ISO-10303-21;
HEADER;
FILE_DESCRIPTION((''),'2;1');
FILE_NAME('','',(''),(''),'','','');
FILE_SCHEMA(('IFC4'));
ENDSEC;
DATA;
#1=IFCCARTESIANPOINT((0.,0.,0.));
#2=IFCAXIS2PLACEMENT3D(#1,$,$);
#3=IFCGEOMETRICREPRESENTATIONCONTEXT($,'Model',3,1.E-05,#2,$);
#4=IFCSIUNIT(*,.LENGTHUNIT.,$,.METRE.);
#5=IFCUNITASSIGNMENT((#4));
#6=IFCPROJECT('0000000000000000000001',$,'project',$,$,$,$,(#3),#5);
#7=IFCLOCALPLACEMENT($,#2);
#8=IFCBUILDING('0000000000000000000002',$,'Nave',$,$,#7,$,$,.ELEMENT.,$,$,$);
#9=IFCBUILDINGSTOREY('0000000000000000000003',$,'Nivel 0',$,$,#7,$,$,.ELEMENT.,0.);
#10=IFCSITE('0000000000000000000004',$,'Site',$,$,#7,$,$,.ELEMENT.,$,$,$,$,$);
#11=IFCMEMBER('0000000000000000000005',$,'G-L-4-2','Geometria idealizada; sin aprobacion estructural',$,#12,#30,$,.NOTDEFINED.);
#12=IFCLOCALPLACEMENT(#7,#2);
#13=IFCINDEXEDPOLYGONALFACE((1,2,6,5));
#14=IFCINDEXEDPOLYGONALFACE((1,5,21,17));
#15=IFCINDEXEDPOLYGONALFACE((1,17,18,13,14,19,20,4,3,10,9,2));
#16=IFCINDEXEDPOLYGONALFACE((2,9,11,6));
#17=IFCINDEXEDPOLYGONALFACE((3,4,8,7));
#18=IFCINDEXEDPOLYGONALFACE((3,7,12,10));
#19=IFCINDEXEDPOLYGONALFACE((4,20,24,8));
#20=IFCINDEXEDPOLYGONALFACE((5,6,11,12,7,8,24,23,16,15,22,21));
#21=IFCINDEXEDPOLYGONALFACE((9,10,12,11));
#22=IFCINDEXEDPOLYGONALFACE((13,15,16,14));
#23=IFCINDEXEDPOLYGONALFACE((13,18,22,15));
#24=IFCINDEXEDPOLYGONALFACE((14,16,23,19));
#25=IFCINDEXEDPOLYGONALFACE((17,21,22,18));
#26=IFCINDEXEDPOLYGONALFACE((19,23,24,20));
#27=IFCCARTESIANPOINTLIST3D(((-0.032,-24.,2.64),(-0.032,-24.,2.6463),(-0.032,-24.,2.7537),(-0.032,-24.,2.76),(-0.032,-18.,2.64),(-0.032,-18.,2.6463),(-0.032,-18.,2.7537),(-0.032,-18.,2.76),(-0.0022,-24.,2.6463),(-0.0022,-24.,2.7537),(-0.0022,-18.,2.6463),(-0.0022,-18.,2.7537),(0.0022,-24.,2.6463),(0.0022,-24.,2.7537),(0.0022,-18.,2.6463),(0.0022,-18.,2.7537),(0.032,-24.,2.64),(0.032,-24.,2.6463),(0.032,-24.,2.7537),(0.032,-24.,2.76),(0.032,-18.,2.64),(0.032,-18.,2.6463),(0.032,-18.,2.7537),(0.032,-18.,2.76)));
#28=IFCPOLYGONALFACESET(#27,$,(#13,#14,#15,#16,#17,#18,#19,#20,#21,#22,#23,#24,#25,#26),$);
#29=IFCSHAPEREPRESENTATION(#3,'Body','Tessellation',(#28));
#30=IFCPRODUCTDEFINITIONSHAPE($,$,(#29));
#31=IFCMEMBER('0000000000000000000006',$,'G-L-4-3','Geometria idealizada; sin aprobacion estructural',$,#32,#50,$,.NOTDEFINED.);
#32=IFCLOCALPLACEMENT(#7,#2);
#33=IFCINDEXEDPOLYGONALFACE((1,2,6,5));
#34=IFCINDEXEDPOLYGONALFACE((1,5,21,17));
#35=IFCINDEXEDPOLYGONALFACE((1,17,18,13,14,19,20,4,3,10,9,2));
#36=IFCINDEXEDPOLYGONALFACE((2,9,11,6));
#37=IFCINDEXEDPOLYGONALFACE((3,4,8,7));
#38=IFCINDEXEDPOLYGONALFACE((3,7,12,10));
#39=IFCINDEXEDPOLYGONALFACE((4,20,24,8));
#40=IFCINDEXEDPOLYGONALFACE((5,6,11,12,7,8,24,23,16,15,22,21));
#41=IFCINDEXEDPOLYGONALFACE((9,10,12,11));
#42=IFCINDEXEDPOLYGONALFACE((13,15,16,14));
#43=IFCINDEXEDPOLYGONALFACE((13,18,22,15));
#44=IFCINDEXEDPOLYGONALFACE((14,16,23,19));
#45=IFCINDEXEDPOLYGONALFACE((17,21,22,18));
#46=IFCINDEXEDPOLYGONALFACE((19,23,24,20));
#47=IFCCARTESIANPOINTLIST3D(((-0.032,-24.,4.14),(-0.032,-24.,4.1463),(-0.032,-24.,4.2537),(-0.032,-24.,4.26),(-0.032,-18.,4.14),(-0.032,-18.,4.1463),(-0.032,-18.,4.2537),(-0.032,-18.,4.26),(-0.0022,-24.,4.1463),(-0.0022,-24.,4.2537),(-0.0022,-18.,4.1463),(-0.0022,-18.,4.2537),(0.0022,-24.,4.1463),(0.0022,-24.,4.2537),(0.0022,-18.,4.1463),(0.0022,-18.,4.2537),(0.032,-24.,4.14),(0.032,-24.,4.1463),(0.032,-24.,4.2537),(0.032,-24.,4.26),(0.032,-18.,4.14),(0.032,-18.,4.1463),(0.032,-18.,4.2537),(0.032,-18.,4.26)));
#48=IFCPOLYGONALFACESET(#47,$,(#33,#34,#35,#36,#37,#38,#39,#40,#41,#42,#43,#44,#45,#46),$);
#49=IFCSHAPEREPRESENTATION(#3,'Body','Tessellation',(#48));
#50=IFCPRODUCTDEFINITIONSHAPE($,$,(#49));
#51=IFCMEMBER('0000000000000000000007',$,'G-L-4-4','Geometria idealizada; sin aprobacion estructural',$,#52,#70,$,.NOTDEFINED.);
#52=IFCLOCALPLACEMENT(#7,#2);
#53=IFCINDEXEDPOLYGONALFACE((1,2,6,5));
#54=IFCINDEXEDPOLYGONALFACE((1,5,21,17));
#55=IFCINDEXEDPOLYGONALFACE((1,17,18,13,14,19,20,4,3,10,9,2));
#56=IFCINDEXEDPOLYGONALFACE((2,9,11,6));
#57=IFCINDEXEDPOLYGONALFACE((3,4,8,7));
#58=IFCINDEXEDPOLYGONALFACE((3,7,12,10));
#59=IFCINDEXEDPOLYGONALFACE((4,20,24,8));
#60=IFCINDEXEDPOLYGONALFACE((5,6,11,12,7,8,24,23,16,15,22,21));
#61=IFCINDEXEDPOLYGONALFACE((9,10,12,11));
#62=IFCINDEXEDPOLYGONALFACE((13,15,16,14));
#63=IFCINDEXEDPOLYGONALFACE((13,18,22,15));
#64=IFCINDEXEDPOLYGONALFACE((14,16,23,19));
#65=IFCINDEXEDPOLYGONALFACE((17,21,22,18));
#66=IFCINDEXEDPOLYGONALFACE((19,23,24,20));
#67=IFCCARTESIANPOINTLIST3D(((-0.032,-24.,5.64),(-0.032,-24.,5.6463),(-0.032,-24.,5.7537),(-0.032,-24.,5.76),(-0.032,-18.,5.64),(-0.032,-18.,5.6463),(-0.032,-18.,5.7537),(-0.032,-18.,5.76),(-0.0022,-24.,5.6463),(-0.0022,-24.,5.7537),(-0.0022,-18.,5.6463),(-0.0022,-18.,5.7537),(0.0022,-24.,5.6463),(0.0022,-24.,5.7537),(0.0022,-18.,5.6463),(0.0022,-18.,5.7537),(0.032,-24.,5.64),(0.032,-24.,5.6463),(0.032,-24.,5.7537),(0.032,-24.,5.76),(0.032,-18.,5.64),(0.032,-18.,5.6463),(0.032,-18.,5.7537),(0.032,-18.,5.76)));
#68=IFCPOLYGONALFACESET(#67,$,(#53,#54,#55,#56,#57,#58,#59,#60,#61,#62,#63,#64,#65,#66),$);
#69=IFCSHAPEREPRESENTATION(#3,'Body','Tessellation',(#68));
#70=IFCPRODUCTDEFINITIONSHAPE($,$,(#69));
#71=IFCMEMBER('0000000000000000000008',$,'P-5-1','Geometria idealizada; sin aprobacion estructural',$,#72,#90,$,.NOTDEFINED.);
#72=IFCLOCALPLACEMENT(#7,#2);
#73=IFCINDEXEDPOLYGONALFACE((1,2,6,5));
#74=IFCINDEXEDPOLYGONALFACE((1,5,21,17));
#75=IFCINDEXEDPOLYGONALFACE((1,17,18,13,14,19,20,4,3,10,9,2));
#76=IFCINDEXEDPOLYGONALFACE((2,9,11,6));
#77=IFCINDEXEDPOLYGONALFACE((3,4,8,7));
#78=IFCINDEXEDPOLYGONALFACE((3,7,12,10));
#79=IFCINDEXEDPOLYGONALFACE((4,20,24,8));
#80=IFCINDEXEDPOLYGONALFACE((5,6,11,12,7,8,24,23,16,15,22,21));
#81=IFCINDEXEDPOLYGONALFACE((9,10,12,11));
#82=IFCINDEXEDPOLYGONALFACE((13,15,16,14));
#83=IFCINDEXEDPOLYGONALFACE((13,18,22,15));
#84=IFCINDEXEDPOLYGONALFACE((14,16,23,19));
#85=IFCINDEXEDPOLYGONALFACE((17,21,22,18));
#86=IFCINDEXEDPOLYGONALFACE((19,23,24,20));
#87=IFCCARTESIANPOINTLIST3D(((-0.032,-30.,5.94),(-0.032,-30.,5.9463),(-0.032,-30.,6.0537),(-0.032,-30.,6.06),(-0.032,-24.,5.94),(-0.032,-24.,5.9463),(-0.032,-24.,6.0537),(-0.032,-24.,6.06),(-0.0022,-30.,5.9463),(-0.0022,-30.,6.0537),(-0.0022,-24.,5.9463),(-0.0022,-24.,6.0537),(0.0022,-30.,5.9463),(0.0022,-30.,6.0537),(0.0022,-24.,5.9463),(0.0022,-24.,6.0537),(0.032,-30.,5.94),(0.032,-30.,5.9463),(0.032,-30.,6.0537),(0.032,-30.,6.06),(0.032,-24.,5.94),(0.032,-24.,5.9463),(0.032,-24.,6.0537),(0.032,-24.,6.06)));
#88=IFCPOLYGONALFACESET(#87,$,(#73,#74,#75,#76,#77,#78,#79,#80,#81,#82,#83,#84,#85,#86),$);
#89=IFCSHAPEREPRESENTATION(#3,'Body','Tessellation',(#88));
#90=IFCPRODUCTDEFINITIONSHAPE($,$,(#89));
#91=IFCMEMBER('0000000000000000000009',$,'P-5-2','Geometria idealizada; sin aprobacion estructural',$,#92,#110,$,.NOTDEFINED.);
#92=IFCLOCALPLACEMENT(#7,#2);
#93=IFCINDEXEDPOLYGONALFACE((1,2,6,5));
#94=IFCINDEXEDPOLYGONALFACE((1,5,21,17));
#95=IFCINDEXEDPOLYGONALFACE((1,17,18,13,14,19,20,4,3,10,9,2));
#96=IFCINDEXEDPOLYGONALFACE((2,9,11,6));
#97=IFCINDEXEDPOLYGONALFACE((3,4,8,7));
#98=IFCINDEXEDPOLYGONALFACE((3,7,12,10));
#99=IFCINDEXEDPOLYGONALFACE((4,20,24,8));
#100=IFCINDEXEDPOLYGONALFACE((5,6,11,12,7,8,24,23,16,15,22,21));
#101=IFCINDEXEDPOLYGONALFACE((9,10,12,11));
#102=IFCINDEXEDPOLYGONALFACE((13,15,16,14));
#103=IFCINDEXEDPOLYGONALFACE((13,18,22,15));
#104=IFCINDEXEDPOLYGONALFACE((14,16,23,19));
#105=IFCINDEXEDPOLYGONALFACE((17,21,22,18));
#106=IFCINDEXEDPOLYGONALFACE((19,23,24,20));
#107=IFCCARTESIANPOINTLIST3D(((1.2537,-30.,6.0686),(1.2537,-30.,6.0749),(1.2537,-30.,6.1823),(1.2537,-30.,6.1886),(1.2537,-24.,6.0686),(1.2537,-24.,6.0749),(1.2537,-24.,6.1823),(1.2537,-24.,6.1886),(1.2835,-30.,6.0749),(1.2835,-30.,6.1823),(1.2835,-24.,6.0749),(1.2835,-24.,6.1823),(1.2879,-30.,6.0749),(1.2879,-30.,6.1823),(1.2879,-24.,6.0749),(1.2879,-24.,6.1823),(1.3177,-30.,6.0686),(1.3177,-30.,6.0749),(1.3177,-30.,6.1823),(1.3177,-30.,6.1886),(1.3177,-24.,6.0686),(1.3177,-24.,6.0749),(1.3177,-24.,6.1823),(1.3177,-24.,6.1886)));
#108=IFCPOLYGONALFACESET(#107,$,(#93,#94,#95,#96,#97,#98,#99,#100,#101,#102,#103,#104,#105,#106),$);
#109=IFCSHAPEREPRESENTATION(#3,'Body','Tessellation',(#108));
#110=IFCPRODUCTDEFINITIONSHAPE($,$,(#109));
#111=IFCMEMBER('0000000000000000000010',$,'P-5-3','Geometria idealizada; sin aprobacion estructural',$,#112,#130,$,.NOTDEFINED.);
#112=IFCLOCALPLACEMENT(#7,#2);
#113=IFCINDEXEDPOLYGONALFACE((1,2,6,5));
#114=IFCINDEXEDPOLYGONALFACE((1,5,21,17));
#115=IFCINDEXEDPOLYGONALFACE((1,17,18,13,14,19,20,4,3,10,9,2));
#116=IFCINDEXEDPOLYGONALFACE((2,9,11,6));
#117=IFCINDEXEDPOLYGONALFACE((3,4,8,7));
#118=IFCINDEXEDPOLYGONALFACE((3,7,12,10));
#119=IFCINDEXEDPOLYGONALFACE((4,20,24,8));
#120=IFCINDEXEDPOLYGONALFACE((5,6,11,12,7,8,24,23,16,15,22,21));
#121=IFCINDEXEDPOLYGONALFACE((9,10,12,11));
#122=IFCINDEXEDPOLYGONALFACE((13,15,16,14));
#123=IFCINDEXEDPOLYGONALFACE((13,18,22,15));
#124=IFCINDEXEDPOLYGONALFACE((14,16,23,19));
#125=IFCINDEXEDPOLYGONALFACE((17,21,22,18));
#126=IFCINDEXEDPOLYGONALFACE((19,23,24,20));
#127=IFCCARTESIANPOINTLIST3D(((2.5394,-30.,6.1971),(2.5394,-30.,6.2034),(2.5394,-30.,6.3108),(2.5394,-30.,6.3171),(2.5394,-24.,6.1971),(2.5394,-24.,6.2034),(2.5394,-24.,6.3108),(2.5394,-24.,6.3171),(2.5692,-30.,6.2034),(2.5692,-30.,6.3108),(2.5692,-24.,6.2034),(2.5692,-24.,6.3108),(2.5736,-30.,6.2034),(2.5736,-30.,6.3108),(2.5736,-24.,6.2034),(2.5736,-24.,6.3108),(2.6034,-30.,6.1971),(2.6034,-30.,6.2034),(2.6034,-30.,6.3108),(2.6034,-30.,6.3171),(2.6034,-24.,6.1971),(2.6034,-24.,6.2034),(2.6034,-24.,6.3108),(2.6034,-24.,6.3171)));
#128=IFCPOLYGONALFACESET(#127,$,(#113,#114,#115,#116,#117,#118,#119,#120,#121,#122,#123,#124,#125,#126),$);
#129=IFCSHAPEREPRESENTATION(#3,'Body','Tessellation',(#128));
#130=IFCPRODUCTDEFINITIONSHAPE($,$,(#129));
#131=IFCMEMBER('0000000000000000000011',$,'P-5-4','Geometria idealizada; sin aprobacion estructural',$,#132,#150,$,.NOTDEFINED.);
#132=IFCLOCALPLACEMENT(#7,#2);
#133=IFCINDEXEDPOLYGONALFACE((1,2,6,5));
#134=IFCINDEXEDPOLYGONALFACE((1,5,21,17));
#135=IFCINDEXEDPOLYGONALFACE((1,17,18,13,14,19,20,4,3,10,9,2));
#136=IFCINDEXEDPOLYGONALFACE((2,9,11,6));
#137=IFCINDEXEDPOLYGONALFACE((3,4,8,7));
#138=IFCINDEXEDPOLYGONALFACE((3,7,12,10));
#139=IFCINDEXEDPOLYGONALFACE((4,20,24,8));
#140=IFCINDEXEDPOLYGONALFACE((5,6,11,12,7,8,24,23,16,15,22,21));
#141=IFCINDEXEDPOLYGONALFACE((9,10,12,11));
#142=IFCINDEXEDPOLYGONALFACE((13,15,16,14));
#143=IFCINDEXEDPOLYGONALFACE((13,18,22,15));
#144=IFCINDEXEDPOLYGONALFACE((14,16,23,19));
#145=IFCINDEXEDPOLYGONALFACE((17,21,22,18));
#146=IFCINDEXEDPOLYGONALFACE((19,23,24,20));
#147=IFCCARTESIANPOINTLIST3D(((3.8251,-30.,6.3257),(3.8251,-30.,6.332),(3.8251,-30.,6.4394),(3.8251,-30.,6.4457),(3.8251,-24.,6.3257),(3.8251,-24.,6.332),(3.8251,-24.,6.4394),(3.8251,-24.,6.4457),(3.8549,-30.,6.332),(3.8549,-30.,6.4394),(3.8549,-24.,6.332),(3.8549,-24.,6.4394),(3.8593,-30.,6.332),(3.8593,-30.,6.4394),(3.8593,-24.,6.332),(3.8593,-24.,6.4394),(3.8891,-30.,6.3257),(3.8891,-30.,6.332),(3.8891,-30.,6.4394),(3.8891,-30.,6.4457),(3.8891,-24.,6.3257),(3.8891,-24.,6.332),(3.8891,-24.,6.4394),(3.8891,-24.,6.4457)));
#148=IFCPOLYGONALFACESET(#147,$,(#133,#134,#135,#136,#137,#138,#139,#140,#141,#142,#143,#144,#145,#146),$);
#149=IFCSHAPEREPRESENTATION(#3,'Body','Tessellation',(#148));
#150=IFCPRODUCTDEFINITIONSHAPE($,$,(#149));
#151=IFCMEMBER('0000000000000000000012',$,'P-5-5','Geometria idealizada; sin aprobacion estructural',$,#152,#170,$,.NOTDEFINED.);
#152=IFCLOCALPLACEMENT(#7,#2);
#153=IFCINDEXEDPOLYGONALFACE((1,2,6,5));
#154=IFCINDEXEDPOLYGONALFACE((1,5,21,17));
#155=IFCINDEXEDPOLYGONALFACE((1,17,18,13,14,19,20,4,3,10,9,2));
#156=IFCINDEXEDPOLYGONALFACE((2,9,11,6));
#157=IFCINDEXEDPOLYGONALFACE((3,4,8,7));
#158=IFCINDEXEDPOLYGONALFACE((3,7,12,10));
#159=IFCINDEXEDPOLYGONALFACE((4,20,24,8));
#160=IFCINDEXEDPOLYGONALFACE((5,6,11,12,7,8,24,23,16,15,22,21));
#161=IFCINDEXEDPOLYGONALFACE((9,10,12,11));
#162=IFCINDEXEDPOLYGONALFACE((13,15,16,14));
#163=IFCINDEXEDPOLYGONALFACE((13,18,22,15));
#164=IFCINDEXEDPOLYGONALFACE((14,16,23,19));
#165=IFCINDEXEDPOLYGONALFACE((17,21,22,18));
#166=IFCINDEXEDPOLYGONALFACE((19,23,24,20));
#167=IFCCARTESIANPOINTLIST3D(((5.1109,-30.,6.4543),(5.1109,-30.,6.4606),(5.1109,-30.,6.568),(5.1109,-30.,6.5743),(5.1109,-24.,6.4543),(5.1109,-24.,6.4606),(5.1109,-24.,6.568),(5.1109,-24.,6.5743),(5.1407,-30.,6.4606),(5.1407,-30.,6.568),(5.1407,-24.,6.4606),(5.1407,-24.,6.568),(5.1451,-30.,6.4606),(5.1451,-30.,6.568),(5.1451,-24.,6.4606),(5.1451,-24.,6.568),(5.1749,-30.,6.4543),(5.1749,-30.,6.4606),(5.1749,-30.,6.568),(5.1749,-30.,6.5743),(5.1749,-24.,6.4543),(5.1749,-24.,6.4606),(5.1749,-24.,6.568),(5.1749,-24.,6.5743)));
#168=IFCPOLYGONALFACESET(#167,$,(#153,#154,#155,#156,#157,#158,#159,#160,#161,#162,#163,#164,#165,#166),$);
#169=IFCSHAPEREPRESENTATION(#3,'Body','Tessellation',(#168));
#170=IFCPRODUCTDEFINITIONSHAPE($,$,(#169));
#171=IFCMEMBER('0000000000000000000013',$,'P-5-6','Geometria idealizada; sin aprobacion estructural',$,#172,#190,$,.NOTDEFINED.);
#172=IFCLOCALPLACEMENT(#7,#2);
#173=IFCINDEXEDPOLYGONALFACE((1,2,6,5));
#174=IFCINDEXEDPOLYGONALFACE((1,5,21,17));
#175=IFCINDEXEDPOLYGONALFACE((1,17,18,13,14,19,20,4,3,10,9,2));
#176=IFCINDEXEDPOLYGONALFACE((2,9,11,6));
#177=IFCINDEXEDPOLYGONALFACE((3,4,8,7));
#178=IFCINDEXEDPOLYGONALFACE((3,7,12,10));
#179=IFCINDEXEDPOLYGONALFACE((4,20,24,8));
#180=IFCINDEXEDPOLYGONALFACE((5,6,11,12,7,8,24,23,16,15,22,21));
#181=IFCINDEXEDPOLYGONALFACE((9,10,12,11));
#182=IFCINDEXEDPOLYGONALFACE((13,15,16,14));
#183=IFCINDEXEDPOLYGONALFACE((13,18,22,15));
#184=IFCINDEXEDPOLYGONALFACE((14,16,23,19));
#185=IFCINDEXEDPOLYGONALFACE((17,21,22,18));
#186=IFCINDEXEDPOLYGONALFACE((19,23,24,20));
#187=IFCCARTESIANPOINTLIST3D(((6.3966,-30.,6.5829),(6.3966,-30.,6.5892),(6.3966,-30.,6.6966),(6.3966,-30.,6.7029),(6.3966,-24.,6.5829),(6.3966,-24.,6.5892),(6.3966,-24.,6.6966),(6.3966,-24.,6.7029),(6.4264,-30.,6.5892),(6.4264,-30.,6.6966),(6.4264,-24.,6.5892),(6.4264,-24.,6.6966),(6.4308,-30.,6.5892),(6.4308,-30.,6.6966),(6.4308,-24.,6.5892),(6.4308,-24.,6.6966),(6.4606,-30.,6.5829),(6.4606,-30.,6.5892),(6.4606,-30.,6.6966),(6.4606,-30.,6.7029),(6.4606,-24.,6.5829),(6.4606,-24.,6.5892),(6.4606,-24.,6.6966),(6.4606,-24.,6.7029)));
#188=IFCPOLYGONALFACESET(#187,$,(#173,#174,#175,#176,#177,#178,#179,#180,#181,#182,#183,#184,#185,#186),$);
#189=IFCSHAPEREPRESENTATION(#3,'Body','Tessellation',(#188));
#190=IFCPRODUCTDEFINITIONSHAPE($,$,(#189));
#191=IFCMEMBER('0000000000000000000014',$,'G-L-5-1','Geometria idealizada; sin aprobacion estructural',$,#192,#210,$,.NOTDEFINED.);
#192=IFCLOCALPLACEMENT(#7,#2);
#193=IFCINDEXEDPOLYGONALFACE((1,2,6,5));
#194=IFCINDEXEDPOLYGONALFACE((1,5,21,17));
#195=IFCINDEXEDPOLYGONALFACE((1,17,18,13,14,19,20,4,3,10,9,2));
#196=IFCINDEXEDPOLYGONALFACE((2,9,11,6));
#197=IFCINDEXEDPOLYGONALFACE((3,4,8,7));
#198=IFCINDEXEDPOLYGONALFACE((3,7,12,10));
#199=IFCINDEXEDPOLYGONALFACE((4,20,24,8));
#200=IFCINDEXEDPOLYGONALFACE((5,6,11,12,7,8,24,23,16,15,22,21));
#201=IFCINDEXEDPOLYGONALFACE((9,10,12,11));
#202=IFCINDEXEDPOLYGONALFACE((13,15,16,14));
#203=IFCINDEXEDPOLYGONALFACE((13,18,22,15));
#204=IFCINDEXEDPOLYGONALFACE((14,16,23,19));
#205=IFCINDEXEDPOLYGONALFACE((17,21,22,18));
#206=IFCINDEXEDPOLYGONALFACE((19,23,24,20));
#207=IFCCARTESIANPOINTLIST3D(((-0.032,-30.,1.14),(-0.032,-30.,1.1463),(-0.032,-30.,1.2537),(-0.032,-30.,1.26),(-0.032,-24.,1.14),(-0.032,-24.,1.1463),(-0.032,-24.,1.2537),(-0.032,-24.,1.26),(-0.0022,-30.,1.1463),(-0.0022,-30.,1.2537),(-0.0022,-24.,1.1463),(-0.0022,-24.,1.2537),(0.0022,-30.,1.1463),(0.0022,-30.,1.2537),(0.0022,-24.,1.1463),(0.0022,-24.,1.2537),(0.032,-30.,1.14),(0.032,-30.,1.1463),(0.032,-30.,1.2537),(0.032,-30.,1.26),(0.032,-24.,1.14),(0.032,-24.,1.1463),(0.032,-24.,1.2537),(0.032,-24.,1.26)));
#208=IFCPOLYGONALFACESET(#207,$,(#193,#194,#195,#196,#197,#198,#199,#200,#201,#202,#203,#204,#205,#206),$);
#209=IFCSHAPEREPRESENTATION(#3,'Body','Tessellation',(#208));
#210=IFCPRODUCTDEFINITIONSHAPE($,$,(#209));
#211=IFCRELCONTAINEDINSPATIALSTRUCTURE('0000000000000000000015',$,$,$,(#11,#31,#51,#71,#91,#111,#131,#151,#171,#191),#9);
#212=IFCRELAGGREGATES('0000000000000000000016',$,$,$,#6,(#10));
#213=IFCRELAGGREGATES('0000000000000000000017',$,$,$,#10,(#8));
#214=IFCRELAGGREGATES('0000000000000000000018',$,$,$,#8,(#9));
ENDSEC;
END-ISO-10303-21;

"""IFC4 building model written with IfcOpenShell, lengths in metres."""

from ifc_helpers import new_model, si_unit, frame, origin, place, context, project, spatial, polyline, outline, extrude, element, save


model = new_model("IFC4")

# Units and contexts
model_context = context("Model", 3, precision=1e-05, world=origin())
ifc_project = project(units=[si_unit("LENGTHUNIT", "METRE")], contexts=[model_context])

# Site, building, storey
placement = place(None, origin())
site = spatial("IfcSite", under=ifc_project, at=placement, Name="Site", CompositionType="ELEMENT")
building = spatial("IfcBuilding", under=site, at=placement, Name="Nave", CompositionType="ELEMENT")
storey = spatial("IfcBuildingStorey", under=building, at=placement, Name="Nivel 0", CompositionType="ELEMENT", Elevation=0.0)

# Members
for number, where, z_axis, x_axis, name in (
    (1, (0.0, -18.0, 2.7), (0.0, -1.0, 0.0), (1.0, 0.0, 0.0), "G-L-4-2"),
    (2, (0.0, -18.0, 4.2), (0.0, -1.0, 0.0), (1.0, 0.0, 0.0), "G-L-4-3"),
    (3, (0.0, -18.0, 5.7), (0.0, -1.0, 0.0), (1.0, 0.0, 0.0), "G-L-4-4"),
    (4, (0.0, -24.0, 6.0), (0.0, -1.0, 0.0), (1.0, 0.0, 0.0), "P-5-1"),
    (5, (1.2857, -24.0, 6.1286), (0.0, -1.0, 0.0), (1.0, 0.0, 0.0), "P-5-2"),
    (6, (2.5714, -24.0, 6.2571), (0.0, -1.0, 0.0), (1.0, 0.0, 0.0), "P-5-3"),
    (7, (3.8571, -24.0, 6.3857), (0.0, -1.0, 0.0), (1.0, 0.0, 0.0), "P-5-4"),
    (8, (5.1429, -24.0, 6.5143), (0.0, -1.0, 0.0), (1.0, 0.0, 0.0), "P-5-5"),
    (9, (6.4286, -24.0, 6.6429), (0.0, -1.0, 0.0), (1.0, 0.0, 0.0), "P-5-6"),
    (10, (0.0, -24.0, 1.2), (0.0, -1.0, 0.0), (1.0, 0.0, 0.0), "G-L-5-1"),
):
    element("IfcMember", number, at=place(placement, frame(where, z_axis=z_axis, x_axis=x_axis)), inside=storey, Name=name, Description="Geometria idealizada; sin aprobacion estructural", PredefinedType="NOTDEFINED", context=model_context, shape_type="SweptSolid", body=[
        extrude(outline(polyline([(-0.032, -0.06), (0.032, -0.06), (0.032, -0.0537), (0.0022, -0.0537), (0.0022, 0.0537), (0.032, 0.0537), (0.032, 0.06), (-0.032, 0.06), (-0.032, 0.0537), (-0.0022, 0.0537), (-0.0022, -0.0537), (-0.032, -0.0537), (-0.032, -0.06)])), origin(), (0.0, 0.0, 1.0), 6.0),
    ])

save(model, "model.ifc")
